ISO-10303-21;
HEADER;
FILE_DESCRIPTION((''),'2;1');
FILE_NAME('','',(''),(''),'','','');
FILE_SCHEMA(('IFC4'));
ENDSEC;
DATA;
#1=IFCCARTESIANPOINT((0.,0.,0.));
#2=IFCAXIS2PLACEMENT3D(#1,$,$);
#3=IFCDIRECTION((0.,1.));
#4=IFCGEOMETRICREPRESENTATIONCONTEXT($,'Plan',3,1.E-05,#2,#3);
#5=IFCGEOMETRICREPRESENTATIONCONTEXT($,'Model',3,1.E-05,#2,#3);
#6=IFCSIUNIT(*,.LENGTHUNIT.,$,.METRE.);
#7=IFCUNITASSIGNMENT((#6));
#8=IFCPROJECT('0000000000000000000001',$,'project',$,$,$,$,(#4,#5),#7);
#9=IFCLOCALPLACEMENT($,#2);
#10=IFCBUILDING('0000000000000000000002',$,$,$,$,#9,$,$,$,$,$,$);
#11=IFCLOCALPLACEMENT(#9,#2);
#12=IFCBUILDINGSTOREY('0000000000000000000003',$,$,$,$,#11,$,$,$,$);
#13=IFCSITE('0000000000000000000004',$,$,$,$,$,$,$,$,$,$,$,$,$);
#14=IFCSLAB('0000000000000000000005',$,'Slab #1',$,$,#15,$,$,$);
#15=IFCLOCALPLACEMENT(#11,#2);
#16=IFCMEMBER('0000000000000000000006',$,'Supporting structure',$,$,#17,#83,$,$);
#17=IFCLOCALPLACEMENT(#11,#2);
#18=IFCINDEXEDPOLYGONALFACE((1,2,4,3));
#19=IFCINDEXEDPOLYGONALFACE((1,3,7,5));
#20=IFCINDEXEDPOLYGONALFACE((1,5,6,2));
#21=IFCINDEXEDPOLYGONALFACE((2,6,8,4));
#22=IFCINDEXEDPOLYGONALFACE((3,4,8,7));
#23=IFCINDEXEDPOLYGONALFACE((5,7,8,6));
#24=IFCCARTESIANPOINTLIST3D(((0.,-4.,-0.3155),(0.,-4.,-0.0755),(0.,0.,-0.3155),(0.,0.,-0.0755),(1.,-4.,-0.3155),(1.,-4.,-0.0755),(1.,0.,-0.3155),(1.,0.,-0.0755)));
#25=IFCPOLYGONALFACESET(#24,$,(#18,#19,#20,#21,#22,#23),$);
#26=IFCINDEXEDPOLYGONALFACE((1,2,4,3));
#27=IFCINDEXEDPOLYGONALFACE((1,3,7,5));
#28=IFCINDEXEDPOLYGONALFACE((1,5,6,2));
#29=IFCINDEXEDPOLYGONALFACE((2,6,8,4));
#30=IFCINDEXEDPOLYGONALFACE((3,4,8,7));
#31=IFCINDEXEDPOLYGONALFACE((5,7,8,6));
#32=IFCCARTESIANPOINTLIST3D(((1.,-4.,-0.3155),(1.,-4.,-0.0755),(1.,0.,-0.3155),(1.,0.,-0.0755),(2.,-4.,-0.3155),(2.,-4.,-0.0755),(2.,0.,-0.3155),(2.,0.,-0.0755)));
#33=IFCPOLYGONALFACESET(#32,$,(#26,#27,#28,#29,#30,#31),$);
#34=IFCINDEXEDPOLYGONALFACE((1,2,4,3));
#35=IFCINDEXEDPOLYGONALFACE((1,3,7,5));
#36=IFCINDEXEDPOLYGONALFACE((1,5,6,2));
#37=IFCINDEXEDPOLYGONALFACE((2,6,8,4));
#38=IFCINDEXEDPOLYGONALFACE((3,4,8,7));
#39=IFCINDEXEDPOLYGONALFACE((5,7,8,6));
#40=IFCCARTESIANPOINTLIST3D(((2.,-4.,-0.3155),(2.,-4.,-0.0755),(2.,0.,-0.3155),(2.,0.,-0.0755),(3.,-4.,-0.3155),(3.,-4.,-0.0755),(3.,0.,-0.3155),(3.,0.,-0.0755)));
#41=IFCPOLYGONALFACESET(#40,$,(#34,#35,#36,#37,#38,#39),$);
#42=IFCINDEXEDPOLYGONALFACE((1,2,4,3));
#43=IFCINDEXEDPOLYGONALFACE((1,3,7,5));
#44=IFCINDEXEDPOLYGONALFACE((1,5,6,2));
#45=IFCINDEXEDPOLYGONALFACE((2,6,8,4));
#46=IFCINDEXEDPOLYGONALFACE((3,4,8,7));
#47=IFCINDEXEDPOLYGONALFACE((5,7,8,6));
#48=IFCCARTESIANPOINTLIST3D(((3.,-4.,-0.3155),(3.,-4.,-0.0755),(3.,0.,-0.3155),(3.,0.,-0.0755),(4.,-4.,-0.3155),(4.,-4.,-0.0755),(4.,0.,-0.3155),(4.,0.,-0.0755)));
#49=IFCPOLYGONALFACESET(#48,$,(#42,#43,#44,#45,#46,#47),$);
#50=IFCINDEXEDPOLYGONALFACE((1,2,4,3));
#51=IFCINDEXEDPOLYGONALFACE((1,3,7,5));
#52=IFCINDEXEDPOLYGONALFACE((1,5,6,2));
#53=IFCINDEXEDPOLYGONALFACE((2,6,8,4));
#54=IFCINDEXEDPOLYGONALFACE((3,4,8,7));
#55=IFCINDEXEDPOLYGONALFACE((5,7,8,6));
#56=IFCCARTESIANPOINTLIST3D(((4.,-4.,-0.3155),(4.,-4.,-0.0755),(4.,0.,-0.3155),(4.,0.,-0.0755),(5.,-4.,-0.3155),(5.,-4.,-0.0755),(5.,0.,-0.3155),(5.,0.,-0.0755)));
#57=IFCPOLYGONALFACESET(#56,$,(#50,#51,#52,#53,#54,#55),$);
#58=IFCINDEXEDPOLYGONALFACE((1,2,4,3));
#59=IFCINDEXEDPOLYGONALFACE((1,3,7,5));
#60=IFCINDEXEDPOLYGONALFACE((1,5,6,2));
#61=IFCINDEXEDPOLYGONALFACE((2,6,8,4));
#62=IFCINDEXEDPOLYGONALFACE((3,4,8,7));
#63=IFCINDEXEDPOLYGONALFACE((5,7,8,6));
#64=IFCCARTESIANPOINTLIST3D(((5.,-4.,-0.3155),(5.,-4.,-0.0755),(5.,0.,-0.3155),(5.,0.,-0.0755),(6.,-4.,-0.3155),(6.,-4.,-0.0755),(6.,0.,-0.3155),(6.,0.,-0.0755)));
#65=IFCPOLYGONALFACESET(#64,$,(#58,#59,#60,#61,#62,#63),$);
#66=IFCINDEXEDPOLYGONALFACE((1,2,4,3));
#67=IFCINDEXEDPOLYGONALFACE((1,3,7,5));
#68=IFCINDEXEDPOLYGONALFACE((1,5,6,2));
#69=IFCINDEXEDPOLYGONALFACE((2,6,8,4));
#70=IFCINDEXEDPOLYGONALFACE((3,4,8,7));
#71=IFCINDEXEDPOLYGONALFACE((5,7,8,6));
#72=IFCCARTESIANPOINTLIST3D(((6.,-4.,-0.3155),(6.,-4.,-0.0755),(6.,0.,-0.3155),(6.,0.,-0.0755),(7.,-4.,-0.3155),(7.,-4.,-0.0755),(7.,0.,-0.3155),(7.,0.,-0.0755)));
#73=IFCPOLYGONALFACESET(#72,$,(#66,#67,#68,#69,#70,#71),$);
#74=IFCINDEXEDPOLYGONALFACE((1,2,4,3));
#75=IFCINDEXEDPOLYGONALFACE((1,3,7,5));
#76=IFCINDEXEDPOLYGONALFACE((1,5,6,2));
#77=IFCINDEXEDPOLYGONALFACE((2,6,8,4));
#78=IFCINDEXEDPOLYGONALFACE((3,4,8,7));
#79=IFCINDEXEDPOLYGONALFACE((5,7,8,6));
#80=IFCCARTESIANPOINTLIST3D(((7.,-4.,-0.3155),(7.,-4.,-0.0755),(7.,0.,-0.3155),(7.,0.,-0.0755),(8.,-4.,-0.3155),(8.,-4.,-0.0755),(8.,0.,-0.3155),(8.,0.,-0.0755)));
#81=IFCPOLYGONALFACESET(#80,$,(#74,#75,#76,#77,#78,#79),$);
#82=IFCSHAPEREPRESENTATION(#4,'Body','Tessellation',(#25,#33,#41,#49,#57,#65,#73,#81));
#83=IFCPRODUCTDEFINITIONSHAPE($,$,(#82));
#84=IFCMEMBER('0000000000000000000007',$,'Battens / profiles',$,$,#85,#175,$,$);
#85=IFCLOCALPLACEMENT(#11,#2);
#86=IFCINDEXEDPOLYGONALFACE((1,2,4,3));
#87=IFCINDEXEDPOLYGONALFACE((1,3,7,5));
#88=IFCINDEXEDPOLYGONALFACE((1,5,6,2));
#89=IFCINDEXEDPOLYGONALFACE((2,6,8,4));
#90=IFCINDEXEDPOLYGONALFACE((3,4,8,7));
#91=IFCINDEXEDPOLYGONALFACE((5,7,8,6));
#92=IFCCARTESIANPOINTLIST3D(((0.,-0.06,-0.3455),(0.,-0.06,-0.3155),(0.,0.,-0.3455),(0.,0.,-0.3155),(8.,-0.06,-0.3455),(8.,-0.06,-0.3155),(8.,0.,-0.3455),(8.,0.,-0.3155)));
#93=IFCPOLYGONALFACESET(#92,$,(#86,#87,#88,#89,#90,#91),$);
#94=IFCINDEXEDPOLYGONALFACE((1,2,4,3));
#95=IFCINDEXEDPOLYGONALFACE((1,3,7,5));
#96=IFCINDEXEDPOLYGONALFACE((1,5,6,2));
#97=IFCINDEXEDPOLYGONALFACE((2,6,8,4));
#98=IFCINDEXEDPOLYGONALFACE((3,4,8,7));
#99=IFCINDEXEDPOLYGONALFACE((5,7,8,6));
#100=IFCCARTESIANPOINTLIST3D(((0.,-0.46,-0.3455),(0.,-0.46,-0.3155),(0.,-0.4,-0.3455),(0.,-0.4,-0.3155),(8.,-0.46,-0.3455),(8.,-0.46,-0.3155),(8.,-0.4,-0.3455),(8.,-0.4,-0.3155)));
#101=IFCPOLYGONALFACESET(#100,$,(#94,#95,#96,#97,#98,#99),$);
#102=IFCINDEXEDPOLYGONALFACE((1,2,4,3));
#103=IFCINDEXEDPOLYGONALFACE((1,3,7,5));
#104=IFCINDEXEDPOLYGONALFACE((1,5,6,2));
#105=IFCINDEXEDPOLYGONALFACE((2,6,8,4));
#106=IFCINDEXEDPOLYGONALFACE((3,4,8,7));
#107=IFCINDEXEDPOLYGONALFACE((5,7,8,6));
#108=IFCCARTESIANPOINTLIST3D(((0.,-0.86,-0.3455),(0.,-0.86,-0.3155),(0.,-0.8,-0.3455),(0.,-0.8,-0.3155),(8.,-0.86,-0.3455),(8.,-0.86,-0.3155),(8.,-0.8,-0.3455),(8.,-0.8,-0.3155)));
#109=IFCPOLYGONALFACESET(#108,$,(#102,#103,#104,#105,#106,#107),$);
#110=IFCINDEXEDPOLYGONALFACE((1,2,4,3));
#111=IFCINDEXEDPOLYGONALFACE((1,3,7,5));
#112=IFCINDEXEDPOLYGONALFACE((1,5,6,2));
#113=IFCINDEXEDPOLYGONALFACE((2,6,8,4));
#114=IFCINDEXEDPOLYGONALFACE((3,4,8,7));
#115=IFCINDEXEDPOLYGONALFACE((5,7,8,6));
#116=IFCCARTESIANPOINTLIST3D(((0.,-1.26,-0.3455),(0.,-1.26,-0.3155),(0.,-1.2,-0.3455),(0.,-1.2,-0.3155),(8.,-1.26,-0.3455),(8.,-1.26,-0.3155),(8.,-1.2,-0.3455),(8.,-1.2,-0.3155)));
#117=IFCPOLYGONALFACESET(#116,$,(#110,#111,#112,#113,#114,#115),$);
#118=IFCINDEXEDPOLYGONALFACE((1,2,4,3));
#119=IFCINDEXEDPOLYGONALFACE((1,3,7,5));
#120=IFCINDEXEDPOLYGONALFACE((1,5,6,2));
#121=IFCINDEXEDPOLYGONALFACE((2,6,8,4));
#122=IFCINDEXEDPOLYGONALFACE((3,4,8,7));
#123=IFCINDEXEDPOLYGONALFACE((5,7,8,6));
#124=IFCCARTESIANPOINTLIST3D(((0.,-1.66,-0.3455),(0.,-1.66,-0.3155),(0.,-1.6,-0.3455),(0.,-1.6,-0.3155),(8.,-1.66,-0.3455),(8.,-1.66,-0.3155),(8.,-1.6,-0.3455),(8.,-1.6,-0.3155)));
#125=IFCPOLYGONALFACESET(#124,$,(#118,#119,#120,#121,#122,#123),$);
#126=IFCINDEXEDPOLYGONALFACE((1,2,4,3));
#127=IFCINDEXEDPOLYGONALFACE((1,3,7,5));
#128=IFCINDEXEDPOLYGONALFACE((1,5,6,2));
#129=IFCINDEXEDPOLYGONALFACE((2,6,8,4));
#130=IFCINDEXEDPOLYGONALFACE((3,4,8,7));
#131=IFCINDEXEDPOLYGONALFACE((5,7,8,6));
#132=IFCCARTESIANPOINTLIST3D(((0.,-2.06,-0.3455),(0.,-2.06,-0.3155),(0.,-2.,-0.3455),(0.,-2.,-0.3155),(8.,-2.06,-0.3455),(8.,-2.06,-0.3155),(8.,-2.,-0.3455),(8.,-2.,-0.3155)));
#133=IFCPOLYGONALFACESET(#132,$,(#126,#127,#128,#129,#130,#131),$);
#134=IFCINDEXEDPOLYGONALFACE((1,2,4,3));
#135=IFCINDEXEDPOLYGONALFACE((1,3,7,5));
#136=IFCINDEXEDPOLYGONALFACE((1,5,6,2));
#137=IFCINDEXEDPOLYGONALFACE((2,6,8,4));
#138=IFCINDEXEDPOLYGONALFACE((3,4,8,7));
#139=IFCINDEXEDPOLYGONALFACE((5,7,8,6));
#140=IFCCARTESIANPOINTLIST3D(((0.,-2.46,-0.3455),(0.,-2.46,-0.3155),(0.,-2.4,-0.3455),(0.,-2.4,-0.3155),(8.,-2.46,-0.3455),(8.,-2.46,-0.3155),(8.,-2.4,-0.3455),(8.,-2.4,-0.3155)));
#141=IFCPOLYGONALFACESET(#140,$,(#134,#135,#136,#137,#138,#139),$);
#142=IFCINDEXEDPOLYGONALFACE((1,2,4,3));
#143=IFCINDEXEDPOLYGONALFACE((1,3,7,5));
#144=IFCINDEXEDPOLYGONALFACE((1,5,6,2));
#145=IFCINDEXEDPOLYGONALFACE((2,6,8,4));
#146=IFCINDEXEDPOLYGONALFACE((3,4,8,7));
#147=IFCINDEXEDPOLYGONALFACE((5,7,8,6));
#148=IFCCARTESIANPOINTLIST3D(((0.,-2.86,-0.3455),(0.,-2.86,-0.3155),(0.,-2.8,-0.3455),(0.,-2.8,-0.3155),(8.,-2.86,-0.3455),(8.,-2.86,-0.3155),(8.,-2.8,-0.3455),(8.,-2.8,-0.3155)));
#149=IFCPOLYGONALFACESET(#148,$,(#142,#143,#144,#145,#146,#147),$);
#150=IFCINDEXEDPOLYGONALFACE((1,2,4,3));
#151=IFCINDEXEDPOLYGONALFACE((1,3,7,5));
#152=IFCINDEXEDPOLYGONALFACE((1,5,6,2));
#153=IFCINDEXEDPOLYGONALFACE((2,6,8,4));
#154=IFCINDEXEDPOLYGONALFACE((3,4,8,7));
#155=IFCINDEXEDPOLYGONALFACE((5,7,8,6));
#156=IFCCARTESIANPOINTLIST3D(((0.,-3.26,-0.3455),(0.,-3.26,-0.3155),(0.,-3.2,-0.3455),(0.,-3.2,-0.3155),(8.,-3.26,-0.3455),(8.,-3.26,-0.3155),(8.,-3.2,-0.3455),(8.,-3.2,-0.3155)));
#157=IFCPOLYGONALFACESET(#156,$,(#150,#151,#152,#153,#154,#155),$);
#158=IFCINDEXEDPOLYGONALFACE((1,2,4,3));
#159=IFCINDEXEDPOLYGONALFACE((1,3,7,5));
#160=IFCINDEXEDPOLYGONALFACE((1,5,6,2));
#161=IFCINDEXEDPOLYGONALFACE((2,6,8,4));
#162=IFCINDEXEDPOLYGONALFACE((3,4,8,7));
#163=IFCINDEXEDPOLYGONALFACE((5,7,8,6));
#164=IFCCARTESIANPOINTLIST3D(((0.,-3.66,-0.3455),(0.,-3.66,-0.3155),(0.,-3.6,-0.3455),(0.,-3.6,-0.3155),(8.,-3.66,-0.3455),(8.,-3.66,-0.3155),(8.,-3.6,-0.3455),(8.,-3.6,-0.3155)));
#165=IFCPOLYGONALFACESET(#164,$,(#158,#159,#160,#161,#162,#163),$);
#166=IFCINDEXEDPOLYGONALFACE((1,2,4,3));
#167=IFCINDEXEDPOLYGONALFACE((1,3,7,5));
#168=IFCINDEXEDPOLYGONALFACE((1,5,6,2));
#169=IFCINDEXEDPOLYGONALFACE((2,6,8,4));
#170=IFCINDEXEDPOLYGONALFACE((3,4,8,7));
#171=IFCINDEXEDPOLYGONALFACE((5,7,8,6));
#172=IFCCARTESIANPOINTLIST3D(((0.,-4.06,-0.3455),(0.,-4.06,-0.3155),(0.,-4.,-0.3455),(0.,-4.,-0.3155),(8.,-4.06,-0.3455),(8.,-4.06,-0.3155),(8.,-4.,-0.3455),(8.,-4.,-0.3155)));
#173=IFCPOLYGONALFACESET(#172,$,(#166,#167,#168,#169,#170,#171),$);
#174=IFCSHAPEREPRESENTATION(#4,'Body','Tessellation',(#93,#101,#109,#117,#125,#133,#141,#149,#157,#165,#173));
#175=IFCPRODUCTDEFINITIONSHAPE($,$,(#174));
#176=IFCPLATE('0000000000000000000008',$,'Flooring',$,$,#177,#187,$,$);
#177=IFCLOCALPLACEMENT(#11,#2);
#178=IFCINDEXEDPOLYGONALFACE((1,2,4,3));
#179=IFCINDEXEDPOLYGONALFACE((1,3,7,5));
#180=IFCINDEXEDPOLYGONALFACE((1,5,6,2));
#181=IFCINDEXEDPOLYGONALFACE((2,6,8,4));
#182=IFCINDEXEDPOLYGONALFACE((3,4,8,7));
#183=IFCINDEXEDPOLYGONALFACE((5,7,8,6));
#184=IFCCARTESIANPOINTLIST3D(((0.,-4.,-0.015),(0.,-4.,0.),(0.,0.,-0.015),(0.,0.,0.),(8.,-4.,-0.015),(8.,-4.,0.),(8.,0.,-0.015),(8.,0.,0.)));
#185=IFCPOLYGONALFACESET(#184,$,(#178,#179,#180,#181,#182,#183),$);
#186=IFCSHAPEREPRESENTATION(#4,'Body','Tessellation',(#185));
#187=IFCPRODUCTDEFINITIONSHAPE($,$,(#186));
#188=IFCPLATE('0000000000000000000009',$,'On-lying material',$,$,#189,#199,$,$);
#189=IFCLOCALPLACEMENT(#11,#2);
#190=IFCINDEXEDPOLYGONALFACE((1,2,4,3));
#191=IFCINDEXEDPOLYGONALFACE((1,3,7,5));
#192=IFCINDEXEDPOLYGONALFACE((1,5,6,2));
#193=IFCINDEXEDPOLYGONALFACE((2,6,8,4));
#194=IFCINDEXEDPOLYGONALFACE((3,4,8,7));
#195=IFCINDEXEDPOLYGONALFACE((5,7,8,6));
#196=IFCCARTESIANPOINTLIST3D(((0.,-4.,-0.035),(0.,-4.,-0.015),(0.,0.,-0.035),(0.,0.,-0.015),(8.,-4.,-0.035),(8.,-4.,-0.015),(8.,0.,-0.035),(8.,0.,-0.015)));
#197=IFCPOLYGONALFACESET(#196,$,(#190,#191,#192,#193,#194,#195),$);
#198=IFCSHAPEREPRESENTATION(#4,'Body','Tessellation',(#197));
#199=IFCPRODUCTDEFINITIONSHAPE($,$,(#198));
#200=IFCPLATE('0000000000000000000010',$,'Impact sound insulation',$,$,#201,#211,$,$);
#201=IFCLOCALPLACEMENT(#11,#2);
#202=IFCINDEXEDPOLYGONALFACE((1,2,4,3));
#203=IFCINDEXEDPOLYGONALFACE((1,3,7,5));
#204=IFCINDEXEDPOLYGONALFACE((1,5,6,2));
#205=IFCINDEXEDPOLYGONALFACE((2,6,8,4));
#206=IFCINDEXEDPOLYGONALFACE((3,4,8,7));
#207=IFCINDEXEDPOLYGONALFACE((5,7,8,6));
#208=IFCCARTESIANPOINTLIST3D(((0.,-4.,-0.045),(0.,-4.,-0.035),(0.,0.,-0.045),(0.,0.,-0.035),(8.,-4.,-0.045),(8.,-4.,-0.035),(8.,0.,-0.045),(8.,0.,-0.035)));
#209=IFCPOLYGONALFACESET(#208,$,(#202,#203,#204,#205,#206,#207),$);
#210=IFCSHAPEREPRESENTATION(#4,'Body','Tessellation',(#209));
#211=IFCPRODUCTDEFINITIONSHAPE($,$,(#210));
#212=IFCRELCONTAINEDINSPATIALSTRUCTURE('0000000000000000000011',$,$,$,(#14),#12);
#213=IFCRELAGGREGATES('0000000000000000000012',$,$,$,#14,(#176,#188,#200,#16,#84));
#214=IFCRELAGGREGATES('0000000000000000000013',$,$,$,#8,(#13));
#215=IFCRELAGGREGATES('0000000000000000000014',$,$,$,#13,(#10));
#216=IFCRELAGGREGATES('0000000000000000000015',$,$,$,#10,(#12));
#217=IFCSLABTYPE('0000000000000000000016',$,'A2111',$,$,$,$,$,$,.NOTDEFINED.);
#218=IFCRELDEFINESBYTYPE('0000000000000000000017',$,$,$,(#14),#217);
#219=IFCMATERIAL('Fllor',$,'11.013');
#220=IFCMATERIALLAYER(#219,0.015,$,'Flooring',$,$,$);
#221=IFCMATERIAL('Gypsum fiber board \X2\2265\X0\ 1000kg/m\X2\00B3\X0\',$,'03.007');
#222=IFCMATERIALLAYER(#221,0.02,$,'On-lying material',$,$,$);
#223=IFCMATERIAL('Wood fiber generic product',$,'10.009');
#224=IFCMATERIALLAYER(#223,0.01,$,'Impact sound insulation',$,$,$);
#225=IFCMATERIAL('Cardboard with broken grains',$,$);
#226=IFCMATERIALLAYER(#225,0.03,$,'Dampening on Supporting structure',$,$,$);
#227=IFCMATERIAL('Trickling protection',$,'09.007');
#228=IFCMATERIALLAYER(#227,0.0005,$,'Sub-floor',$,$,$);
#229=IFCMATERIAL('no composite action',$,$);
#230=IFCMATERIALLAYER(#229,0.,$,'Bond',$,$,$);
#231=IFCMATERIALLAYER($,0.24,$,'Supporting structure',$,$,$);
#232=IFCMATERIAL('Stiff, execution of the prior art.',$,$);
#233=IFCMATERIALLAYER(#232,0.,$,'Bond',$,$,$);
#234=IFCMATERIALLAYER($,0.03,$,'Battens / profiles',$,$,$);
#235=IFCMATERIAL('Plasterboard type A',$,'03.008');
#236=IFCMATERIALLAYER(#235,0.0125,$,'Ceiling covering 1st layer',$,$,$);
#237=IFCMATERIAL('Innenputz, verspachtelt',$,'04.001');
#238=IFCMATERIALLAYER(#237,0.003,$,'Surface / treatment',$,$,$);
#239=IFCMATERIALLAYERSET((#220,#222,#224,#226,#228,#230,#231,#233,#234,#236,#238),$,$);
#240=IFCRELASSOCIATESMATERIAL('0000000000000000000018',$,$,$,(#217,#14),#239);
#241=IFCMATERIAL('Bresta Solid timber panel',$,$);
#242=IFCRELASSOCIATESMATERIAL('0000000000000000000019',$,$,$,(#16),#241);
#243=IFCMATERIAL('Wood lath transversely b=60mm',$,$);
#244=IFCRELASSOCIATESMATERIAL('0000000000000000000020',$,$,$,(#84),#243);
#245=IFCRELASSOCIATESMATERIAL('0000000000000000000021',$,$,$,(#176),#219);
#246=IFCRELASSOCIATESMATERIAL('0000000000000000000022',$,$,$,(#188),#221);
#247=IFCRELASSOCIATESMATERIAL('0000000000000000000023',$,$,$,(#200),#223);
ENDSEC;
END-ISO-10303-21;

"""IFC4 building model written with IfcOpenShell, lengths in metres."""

from ifc_helpers import new_model, si_unit, direction, frame, frame_2d, origin, origin_with_axes, place, context, project, spatial, rectangle, extrude, material, layer, layer_set, type_object, element, aggregate, save


model = new_model("IFC4")

# Units and contexts
plan_context = context("Plan", 3, precision=1e-05, world=origin(), true_north=direction((0.0, 1.0)))
model_context = context("Model", 3, precision=1e-05, world=origin(), true_north=direction((0.0, 1.0)))
ifc_project = project(units=[si_unit("LENGTHUNIT", "METRE")], contexts=[plan_context, model_context])

# Site, building, storey
site = spatial("IfcSite", under=ifc_project)
building_placement = place(None, origin())
building = spatial("IfcBuilding", under=site, at=building_placement)
storey_placement = place(building_placement, origin())
storey = spatial("IfcBuildingStorey", under=building, at=storey_placement)

# Slab, members, plates
ifc_material_1 = material(Name="Fllor", Category="11.013")
ifc_layer_1 = layer(ifc_material_1, 0.015, Name="Flooring")
ifc_material_2 = material(Name="Gypsum fiber board ≥ 1000kg/m³", Category="03.007")
ifc_layer_2 = layer(ifc_material_2, 0.02, Name="On-lying material")
ifc_material_3 = material(Name="Wood fiber generic product", Category="10.009")
ifc_layer_3 = layer(ifc_material_3, 0.01, Name="Impact sound insulation")
ifc_material_4 = material(Name="Cardboard with broken grains")
ifc_layer_4 = layer(ifc_material_4, 0.03, Name="Dampening on Supporting structure")
ifc_material_5 = material(Name="Trickling protection", Category="09.007")
ifc_layer_5 = layer(ifc_material_5, 0.0005, Name="Sub-floor")
ifc_material_6 = material(Name="no composite action")
ifc_layer_6 = layer(ifc_material_6, 0.0, Name="Bond")
ifc_layer_7 = layer(None, 0.24, Name="Supporting structure")
ifc_material_7 = material(Name="Stiff, execution of the prior art.")
ifc_layer_8 = layer(ifc_material_7, 0.0, Name="Bond")
ifc_layer_9 = layer(None, 0.03, Name="Battens / profiles")
ifc_material_8 = material(Name="Plasterboard type A", Category="03.008")
ifc_layer_10 = layer(ifc_material_8, 0.0125, Name="Ceiling covering 1st layer")
ifc_material_9 = material(Name="Innenputz, verspachtelt", Category="04.001")
ifc_layer_11 = layer(ifc_material_9, 0.003, Name="Surface / treatment")
ifc_layer_set = layer_set([ifc_layer_1, ifc_layer_2, ifc_layer_3, ifc_layer_4, ifc_layer_5, ifc_layer_6, ifc_layer_7, ifc_layer_8, ifc_layer_9, ifc_layer_10, ifc_layer_11])
slab_type = type_object("IfcSlabType", Name="A2111", PredefinedType="NOTDEFINED", material=ifc_layer_set)
slab_placement = place(None, frame((0.0, 0.0, 0.0), z_axis=(0.0, 0.0, -1.0), x_axis=(1.0, 0.0, 0.0)))
slab = element("IfcSlab", 1, at=slab_placement, inside=storey, type_object=slab_type, material=ifc_layer_set, Name="Slab #1")
ifc_material_10 = material(Name="Bresta Solid timber panel")
member_1_placement = place(slab_placement, origin())
member_1 = element("IfcMember", 2, at=member_1_placement, material=ifc_material_10, Name="Supporting structure", context=plan_context, shape_type="SweptSolid", body=[
    extrude(rectangle(XDim=1.0, YDim=0.24, at=frame_2d((0.5, 0.12), x_axis=(1.0, 0.0))), frame((0.0, 4.0, 0.0755), z_axis=(0.0, -1.0, 0.0), x_axis=(1.0, 0.0, 0.0)), (0.0, 0.0, 1.0), 4.0),
    extrude(rectangle(XDim=1.0, YDim=0.24, at=frame_2d((0.5, 0.12), x_axis=(1.0, 0.0))), frame((1.0, 4.0, 0.0755), z_axis=(0.0, -1.0, 0.0), x_axis=(1.0, 0.0, 0.0)), (0.0, 0.0, 1.0), 4.0),
    extrude(rectangle(XDim=1.0, YDim=0.24, at=frame_2d((0.5, 0.12), x_axis=(1.0, 0.0))), frame((2.0, 4.0, 0.0755), z_axis=(0.0, -1.0, 0.0), x_axis=(1.0, 0.0, 0.0)), (0.0, 0.0, 1.0), 4.0),
    extrude(rectangle(XDim=1.0, YDim=0.24, at=frame_2d((0.5, 0.12), x_axis=(1.0, 0.0))), frame((3.0, 4.0, 0.0755), z_axis=(0.0, -1.0, 0.0), x_axis=(1.0, 0.0, 0.0)), (0.0, 0.0, 1.0), 4.0),
    extrude(rectangle(XDim=1.0, YDim=0.24, at=frame_2d((0.5, 0.12), x_axis=(1.0, 0.0))), frame((4.0, 4.0, 0.0755), z_axis=(0.0, -1.0, 0.0), x_axis=(1.0, 0.0, 0.0)), (0.0, 0.0, 1.0), 4.0),
    extrude(rectangle(XDim=1.0, YDim=0.24, at=frame_2d((0.5, 0.12), x_axis=(1.0, 0.0))), frame((5.0, 4.0, 0.0755), z_axis=(0.0, -1.0, 0.0), x_axis=(1.0, 0.0, 0.0)), (0.0, 0.0, 1.0), 4.0),
    extrude(rectangle(XDim=1.0, YDim=0.24, at=frame_2d((0.5, 0.12), x_axis=(1.0, 0.0))), frame((6.0, 4.0, 0.0755), z_axis=(0.0, -1.0, 0.0), x_axis=(1.0, 0.0, 0.0)), (0.0, 0.0, 1.0), 4.0),
    extrude(rectangle(XDim=1.0, YDim=0.24, at=frame_2d((0.5, 0.12), x_axis=(1.0, 0.0))), frame((7.0, 4.0, 0.0755), z_axis=(0.0, -1.0, 0.0), x_axis=(1.0, 0.0, 0.0)), (0.0, 0.0, 1.0), 4.0),
])
ifc_material_11 = material(Name="Wood lath transversely b=60mm")
member_2_placement = place(slab_placement, origin())
member_2 = element("IfcMember", 3, at=member_2_placement, material=ifc_material_11, Name="Battens / profiles", context=plan_context, shape_type="SweptSolid", body=[
    extrude(rectangle(XDim=0.06, YDim=0.03, at=frame_2d((0.03, 0.015), x_axis=(1.0, 0.0))), frame((0.0, 0.0, 0.3155), z_axis=(1.0, 0.0, 0.0), x_axis=(0.0, 1.0, 0.0)), (0.0, 0.0, 1.0), 8.0),
    extrude(rectangle(XDim=0.06, YDim=0.03, at=frame_2d((0.03, 0.015), x_axis=(1.0, 0.0))), frame((0.0, 0.4, 0.3155), z_axis=(1.0, 0.0, 0.0), x_axis=(0.0, 1.0, 0.0)), (0.0, 0.0, 1.0), 8.0),
    extrude(rectangle(XDim=0.06, YDim=0.03, at=frame_2d((0.03, 0.015), x_axis=(1.0, 0.0))), frame((0.0, 0.8, 0.3155), z_axis=(1.0, 0.0, 0.0), x_axis=(0.0, 1.0, 0.0)), (0.0, 0.0, 1.0), 8.0),
    extrude(rectangle(XDim=0.06, YDim=0.03, at=frame_2d((0.03, 0.015), x_axis=(1.0, 0.0))), frame((0.0, 1.2, 0.3155), z_axis=(1.0, 0.0, 0.0), x_axis=(0.0, 1.0, 0.0)), (0.0, 0.0, 1.0), 8.0),
    extrude(rectangle(XDim=0.06, YDim=0.03, at=frame_2d((0.03, 0.015), x_axis=(1.0, 0.0))), frame((0.0, 1.6, 0.3155), z_axis=(1.0, 0.0, 0.0), x_axis=(0.0, 1.0, 0.0)), (0.0, 0.0, 1.0), 8.0),
    extrude(rectangle(XDim=0.06, YDim=0.03, at=frame_2d((0.03, 0.015), x_axis=(1.0, 0.0))), frame((0.0, 2.0, 0.3155), z_axis=(1.0, 0.0, 0.0), x_axis=(0.0, 1.0, 0.0)), (0.0, 0.0, 1.0), 8.0),
    extrude(rectangle(XDim=0.06, YDim=0.03, at=frame_2d((0.03, 0.015), x_axis=(1.0, 0.0))), frame((0.0, 2.4, 0.3155), z_axis=(1.0, 0.0, 0.0), x_axis=(0.0, 1.0, 0.0)), (0.0, 0.0, 1.0), 8.0),
    extrude(rectangle(XDim=0.06, YDim=0.03, at=frame_2d((0.03, 0.015), x_axis=(1.0, 0.0))), frame((0.0, 2.8, 0.3155), z_axis=(1.0, 0.0, 0.0), x_axis=(0.0, 1.0, 0.0)), (0.0, 0.0, 1.0), 8.0),
    extrude(rectangle(XDim=0.06, YDim=0.03, at=frame_2d((0.03, 0.015), x_axis=(1.0, 0.0))), frame((0.0, 3.2, 0.3155), z_axis=(1.0, 0.0, 0.0), x_axis=(0.0, 1.0, 0.0)), (0.0, 0.0, 1.0), 8.0),
    extrude(rectangle(XDim=0.06, YDim=0.03, at=frame_2d((0.03, 0.015), x_axis=(1.0, 0.0))), frame((0.0, 3.6, 0.3155), z_axis=(1.0, 0.0, 0.0), x_axis=(0.0, 1.0, 0.0)), (0.0, 0.0, 1.0), 8.0),
    extrude(rectangle(XDim=0.06, YDim=0.03, at=frame_2d((0.03, 0.015), x_axis=(1.0, 0.0))), frame((0.0, 4.0, 0.3155), z_axis=(1.0, 0.0, 0.0), x_axis=(0.0, 1.0, 0.0)), (0.0, 0.0, 1.0), 8.0),
])
plate_1_placement = place(slab_placement, origin())
plate_1 = element("IfcPlate", 4, at=plate_1_placement, material=ifc_material_1, Name="Flooring", context=plan_context, shape_type="SweptSolid", body=[
    extrude(rectangle(XDim=8.0, YDim=4.0, at=frame_2d((4.0, 2.0), x_axis=(1.0, 0.0))), origin_with_axes(), (0.0, 0.0, 1.0), 0.015),
])
plate_2_placement = place(slab_placement, origin())
plate_2 = element("IfcPlate", 5, at=plate_2_placement, material=ifc_material_2, Name="On-lying material", context=plan_context, shape_type="SweptSolid", body=[
    extrude(rectangle(XDim=8.0, YDim=4.0, at=frame_2d((4.0, 2.0), x_axis=(1.0, 0.0))), frame((0.0, 0.0, 0.015), z_axis=(0.0, 0.0, 1.0), x_axis=(1.0, 0.0, 0.0)), (0.0, 0.0, 1.0), 0.02),
])
plate_3_placement = place(slab_placement, origin())
plate_3 = element("IfcPlate", 6, at=plate_3_placement, material=ifc_material_3, Name="Impact sound insulation", context=plan_context, shape_type="SweptSolid", body=[
    extrude(rectangle(XDim=8.0, YDim=4.0, at=frame_2d((4.0, 2.0), x_axis=(1.0, 0.0))), frame((0.0, 0.0, 0.035), z_axis=(0.0, 0.0, 1.0), x_axis=(1.0, 0.0, 0.0)), (0.0, 0.0, 1.0), 0.01),
])
aggregate(slab, [plate_1, plate_2, plate_3, member_1, member_2])

save(model, "model.ifc")
